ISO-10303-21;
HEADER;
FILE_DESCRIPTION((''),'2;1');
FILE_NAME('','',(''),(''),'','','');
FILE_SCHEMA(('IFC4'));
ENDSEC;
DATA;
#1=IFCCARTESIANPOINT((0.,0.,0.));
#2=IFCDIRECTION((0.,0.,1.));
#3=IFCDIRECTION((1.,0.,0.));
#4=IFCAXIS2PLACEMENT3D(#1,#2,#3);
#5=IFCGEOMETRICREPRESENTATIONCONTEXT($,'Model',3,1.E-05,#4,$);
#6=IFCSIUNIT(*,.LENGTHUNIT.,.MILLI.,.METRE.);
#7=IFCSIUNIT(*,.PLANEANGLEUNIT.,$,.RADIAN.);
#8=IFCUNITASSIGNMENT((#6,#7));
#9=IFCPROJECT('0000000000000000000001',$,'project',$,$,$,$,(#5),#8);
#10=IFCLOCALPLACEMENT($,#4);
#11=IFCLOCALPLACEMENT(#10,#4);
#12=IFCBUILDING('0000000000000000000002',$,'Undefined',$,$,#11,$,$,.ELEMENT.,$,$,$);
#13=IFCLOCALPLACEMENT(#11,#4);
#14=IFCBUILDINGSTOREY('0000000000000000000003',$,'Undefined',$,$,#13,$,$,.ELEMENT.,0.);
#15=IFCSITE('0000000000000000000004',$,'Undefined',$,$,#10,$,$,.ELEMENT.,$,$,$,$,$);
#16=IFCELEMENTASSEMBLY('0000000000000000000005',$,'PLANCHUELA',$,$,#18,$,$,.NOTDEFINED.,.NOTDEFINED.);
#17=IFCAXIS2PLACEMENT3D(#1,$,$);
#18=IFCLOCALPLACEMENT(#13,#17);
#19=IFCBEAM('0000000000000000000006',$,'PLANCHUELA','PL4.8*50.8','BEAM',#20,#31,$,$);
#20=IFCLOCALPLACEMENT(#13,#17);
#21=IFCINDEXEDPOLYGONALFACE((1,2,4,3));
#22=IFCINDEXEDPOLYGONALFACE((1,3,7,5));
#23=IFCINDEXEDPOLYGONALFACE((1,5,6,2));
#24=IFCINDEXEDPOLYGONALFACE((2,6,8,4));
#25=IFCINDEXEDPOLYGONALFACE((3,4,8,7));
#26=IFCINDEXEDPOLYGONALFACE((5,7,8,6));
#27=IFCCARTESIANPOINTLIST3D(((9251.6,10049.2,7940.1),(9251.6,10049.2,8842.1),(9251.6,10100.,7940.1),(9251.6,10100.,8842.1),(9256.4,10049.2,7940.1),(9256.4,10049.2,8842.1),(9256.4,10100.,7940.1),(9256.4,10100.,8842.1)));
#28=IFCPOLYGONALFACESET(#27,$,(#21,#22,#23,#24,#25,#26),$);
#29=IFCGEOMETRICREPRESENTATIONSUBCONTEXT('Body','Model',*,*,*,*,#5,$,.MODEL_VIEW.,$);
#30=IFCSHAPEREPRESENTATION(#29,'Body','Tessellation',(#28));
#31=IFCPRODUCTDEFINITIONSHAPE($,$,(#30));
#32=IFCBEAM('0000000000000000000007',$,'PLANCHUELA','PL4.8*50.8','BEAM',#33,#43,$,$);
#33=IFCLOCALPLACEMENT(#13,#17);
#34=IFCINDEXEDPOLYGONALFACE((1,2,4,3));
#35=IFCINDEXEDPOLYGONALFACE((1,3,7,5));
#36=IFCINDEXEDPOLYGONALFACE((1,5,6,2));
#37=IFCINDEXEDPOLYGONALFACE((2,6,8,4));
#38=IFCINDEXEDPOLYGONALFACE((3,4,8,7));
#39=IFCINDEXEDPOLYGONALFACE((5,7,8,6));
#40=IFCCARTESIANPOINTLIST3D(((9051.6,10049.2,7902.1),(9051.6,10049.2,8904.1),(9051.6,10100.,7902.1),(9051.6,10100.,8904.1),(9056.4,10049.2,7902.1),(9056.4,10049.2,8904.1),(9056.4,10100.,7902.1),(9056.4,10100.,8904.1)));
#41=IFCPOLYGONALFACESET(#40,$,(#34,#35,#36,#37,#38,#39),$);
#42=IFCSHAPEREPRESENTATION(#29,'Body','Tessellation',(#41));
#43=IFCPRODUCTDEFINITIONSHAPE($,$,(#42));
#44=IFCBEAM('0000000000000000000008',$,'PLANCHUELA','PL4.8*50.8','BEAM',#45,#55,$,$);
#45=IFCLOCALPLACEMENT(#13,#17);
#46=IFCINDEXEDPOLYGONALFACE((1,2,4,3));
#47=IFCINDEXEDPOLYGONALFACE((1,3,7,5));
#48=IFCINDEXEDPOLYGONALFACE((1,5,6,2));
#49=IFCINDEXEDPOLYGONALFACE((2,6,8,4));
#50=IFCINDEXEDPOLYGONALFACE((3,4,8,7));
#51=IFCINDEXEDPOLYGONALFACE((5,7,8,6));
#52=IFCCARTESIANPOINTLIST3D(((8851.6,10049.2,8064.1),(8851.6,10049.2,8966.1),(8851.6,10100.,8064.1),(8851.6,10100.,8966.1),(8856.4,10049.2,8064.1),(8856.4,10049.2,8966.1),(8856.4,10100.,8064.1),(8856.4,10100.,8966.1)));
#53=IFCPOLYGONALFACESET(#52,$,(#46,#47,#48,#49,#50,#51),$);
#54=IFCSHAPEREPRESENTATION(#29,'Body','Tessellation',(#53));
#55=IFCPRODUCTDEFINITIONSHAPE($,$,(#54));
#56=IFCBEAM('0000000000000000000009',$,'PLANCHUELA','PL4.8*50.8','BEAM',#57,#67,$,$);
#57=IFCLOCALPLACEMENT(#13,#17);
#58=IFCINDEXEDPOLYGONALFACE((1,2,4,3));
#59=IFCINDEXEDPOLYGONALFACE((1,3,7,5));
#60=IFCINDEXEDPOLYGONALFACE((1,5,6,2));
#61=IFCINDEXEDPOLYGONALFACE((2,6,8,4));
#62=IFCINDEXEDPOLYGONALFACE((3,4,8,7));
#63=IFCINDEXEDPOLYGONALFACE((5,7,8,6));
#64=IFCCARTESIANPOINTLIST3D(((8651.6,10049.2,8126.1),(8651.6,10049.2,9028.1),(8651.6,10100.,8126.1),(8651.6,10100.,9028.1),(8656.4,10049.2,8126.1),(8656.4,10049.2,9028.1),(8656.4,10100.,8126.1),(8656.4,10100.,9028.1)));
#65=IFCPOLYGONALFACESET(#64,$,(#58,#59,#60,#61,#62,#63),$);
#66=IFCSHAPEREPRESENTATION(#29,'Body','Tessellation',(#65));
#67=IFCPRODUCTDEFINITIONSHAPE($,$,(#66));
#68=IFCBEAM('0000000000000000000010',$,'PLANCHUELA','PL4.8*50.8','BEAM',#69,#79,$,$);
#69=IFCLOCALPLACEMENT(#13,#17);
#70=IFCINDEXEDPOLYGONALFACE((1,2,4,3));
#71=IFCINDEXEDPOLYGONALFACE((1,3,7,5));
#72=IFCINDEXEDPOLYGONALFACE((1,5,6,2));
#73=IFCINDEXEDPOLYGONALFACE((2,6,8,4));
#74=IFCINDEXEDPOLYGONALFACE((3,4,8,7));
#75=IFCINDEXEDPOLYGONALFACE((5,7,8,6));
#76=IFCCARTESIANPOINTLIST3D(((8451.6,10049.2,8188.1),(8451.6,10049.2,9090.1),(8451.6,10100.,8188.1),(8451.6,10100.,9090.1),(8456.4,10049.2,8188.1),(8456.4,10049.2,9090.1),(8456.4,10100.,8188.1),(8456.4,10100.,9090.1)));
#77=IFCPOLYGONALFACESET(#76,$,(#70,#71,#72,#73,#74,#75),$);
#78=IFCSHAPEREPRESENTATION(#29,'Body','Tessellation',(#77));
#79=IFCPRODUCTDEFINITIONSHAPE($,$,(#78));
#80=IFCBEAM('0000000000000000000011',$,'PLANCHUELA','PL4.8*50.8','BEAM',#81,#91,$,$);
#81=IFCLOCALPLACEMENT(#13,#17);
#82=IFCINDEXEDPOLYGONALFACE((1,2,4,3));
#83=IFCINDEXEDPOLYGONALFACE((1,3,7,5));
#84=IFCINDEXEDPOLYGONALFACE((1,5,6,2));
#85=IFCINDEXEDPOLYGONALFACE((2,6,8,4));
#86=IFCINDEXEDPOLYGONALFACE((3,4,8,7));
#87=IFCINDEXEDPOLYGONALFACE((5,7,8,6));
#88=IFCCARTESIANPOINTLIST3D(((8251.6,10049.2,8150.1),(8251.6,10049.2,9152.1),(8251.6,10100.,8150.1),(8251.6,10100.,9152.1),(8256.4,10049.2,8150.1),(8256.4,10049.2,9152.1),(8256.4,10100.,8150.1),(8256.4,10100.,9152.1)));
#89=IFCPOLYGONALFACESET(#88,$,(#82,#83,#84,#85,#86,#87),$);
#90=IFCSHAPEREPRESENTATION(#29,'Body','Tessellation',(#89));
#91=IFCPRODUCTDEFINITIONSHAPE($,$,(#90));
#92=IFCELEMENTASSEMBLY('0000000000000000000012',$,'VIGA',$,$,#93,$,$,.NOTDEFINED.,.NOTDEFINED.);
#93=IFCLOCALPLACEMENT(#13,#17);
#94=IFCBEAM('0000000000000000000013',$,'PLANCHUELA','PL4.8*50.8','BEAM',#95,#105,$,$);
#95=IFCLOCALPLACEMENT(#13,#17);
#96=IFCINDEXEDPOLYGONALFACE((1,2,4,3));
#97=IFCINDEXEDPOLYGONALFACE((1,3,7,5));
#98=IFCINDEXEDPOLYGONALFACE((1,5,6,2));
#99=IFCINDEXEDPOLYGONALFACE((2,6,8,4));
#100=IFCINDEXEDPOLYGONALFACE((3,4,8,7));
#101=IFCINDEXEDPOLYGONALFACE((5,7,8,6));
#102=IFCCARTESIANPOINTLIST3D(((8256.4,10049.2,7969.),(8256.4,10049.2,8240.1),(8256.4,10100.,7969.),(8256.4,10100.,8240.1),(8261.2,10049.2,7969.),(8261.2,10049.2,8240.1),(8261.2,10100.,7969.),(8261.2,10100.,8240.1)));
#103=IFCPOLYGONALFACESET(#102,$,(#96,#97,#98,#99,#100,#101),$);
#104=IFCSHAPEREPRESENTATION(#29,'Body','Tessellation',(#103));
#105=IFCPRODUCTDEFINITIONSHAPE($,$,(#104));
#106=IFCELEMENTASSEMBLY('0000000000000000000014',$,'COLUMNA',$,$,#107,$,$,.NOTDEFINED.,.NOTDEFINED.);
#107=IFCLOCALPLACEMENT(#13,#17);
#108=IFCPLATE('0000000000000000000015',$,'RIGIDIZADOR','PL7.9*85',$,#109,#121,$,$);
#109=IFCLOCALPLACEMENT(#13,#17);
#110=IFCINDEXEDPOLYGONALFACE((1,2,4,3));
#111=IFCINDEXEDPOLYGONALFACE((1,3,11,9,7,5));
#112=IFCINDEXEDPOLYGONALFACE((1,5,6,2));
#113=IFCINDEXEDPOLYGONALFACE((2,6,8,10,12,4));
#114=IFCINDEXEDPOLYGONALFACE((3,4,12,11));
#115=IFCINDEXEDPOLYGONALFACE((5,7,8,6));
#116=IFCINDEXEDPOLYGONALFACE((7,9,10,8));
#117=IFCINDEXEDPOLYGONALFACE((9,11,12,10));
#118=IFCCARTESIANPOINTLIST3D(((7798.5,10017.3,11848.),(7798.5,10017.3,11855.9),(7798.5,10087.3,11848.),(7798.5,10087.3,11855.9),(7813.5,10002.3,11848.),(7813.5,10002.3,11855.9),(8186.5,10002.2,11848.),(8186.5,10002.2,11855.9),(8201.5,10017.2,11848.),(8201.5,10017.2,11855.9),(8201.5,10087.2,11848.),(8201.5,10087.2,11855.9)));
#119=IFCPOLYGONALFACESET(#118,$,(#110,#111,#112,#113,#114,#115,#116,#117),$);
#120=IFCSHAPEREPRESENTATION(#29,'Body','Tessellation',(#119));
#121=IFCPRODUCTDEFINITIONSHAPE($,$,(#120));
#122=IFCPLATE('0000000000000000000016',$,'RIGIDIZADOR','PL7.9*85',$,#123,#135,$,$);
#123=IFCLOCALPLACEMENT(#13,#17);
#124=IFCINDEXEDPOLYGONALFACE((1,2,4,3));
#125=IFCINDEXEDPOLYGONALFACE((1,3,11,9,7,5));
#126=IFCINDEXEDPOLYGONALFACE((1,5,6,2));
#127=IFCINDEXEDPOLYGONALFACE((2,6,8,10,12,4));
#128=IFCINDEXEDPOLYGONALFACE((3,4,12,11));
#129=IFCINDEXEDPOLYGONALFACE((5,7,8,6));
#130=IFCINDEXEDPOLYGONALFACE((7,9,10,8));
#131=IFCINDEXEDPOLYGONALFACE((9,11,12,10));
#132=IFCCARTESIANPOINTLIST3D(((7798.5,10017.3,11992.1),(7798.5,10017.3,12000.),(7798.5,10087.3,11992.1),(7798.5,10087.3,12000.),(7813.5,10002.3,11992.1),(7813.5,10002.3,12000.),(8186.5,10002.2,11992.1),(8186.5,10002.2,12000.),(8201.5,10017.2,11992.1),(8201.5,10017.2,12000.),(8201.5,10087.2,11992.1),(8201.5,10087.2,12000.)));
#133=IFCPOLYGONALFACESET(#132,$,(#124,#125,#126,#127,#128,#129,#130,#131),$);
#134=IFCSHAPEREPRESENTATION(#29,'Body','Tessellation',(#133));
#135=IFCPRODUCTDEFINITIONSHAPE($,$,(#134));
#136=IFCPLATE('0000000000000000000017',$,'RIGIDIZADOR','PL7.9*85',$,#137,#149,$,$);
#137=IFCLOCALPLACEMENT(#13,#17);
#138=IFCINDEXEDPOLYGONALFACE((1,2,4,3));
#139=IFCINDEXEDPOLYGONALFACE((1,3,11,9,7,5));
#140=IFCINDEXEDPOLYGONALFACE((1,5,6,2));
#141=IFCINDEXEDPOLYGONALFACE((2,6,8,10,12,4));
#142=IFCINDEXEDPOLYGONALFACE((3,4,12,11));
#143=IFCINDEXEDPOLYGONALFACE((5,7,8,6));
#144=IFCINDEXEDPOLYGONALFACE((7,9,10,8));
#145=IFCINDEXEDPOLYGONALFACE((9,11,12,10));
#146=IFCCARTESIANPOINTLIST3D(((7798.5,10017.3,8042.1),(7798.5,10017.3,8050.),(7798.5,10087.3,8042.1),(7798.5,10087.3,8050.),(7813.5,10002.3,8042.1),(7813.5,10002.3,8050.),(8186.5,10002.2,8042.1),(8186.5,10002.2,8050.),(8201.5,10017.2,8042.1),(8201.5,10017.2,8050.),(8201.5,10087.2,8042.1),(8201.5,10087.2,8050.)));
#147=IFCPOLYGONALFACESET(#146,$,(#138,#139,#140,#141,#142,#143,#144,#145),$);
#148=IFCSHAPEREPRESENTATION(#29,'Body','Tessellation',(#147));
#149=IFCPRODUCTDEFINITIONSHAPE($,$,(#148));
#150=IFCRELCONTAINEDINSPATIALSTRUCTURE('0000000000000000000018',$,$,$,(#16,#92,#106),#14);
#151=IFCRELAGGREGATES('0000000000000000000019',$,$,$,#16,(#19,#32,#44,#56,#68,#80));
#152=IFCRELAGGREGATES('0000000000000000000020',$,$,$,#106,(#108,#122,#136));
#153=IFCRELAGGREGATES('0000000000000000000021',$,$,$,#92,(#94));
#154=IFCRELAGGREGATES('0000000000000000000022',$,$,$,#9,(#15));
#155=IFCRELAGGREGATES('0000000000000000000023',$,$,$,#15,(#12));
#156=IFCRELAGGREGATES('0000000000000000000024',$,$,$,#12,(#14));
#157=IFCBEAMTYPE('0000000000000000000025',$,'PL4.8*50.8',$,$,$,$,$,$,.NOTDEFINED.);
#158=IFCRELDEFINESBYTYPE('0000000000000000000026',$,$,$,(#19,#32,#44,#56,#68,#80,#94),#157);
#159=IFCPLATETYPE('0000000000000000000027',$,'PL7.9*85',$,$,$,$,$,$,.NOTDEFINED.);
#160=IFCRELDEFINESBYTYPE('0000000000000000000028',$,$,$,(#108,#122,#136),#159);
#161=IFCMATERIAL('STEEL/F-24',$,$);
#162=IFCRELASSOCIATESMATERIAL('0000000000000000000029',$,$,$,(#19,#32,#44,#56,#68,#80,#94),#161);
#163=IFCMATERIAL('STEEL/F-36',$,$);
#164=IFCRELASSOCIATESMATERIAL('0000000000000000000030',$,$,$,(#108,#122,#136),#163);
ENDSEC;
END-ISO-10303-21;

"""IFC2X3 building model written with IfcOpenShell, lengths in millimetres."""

from ifc_helpers import new_model, si_unit, frame, origin_with_axes, origin_2d_with_axis, place, context, subcontext, project, spatial, polyline, rectangle, outline, extrude, material, type_object, element, aggregate, save


model = new_model("IFC2X3")

# Units and contexts
model_context = context("Model", 3, precision=1e-05, world=origin_with_axes())
body_context = subcontext(model_context, "Body", "Model", "MODEL_VIEW")
ifc_project = project(units=[si_unit("LENGTHUNIT", "METRE", prefix="MILLI"), si_unit("PLANEANGLEUNIT", "RADIAN")], contexts=[model_context])

# Site, building, storey
site_placement = place(None, origin_with_axes())
site = spatial("IfcSite", under=ifc_project, at=site_placement, Name="Undefined", CompositionType="ELEMENT")
building_placement = place(site_placement, origin_with_axes())
building = spatial("IfcBuilding", under=site, at=building_placement, Name="Undefined", CompositionType="ELEMENT")
storey_placement = place(building_placement, origin_with_axes())
storey = spatial("IfcBuildingStorey", under=building, at=storey_placement, Name="Undefined", CompositionType="ELEMENT", Elevation=0.0)

# Element assembly, beams
assembly_1_placement = place(storey_placement, origin_with_axes())
assembly_1 = element("IfcElementAssembly", 1, at=assembly_1_placement, inside=storey, Name="PLANCHUELA", AssemblyPlace="NOTDEFINED", PredefinedType="NOTDEFINED")
ifc_material_1 = material(Name="STEEL/F-24")
beam_type = type_object("IfcBeamType", Name="PL4.8*50.8", PredefinedType="NOTDEFINED")
beam_1_placement = place(assembly_1_placement, frame((9254.0, 10074.6, 8842.1), z_axis=(0.0, -1.0, 0.0), x_axis=(0.0, 0.0, -1.0)))
beam_1 = element("IfcBeam", 2, at=beam_1_placement, type_object=beam_type, material=ifc_material_1, Name="PLANCHUELA", Description="PL4.8*50.8", ObjectType="BEAM", context=body_context, shape_type="SweptSolid", body=[
    extrude(rectangle(XDim=4.8, YDim=50.8, at=origin_2d_with_axis()), frame((902.0, 0.0, 0.0), z_axis=(-1.0, 0.0, 0.0), x_axis=(0.0, -1.0, 0.0)), (0.0, 0.0, 1.0), 902.0),
])
beam_2_placement = place(assembly_1_placement, frame((9054.0, 10074.6, 8904.1), z_axis=(0.0, -1.0, 0.0), x_axis=(0.0, 0.0, -1.0)))
beam_2 = element("IfcBeam", 3, at=beam_2_placement, type_object=beam_type, material=ifc_material_1, Name="PLANCHUELA", Description="PL4.8*50.8", ObjectType="BEAM", context=body_context, shape_type="SweptSolid", body=[
    extrude(rectangle(XDim=4.8, YDim=50.8, at=origin_2d_with_axis()), frame((1002.0, 0.0, 0.0), z_axis=(-1.0, 0.0, 0.0), x_axis=(0.0, -1.0, 0.0)), (0.0, 0.0, 1.0), 1002.0),
])
beam_3_placement = place(assembly_1_placement, frame((8854.0, 10074.6, 8966.1), z_axis=(0.0, -1.0, 0.0), x_axis=(0.0, 0.0, -1.0)))
beam_3 = element("IfcBeam", 4, at=beam_3_placement, type_object=beam_type, material=ifc_material_1, Name="PLANCHUELA", Description="PL4.8*50.8", ObjectType="BEAM", context=body_context, shape_type="SweptSolid", body=[
    extrude(rectangle(XDim=4.8, YDim=50.8, at=origin_2d_with_axis()), frame((902.0, 0.0, 0.0), z_axis=(-1.0, 0.0, 0.0), x_axis=(0.0, -1.0, 0.0)), (0.0, 0.0, 1.0), 902.0),
])
beam_4_placement = place(assembly_1_placement, frame((8654.0, 10074.6, 9028.1), z_axis=(0.0, -1.0, 0.0), x_axis=(0.0, 0.0, -1.0)))
beam_4 = element("IfcBeam", 5, at=beam_4_placement, type_object=beam_type, material=ifc_material_1, Name="PLANCHUELA", Description="PL4.8*50.8", ObjectType="BEAM", context=body_context, shape_type="SweptSolid", body=[
    extrude(rectangle(XDim=4.8, YDim=50.8, at=origin_2d_with_axis()), frame((902.0, 0.0, 0.0), z_axis=(-1.0, 0.0, 0.0), x_axis=(0.0, -1.0, 0.0)), (0.0, 0.0, 1.0), 902.0),
])
beam_5_placement = place(assembly_1_placement, frame((8454.0, 10074.6, 9090.1), z_axis=(0.0, -1.0, 0.0), x_axis=(0.0, 0.0, -1.0)))
beam_5 = element("IfcBeam", 6, at=beam_5_placement, type_object=beam_type, material=ifc_material_1, Name="PLANCHUELA", Description="PL4.8*50.8", ObjectType="BEAM", context=body_context, shape_type="SweptSolid", body=[
    extrude(rectangle(XDim=4.8, YDim=50.8, at=origin_2d_with_axis()), frame((902.0, 0.0, 0.0), z_axis=(-1.0, 0.0, 0.0), x_axis=(0.0, -1.0, 0.0)), (0.0, 0.0, 1.0), 902.0),
])
beam_6_placement = place(assembly_1_placement, frame((8254.0, 10074.6, 9152.1), z_axis=(0.0, -1.0, 0.0), x_axis=(0.0, 0.0, -1.0)))
beam_6 = element("IfcBeam", 7, at=beam_6_placement, type_object=beam_type, material=ifc_material_1, Name="PLANCHUELA", Description="PL4.8*50.8", ObjectType="BEAM", context=body_context, shape_type="SweptSolid", body=[
    extrude(rectangle(XDim=4.8, YDim=50.8, at=origin_2d_with_axis()), frame((1002.0, 0.0, 0.0), z_axis=(-1.0, 0.0, 0.0), x_axis=(0.0, -1.0, 0.0)), (0.0, 0.0, 1.0), 1002.0),
])
aggregate(assembly_1, [beam_1, beam_2, beam_3, beam_4, beam_5, beam_6])

# Element assembly, beam
assembly_2_placement = place(storey_placement, origin_with_axes())
assembly_2 = element("IfcElementAssembly", 8, at=assembly_2_placement, inside=storey, Name="VIGA", AssemblyPlace="NOTDEFINED", PredefinedType="NOTDEFINED")
beam_7_placement = place(assembly_2_placement, frame((8258.8, 10074.6, 8240.1), z_axis=(0.0, 1.0, 0.0), x_axis=(0.0, 0.0, -1.0)))
beam_7 = element("IfcBeam", 9, at=beam_7_placement, type_object=beam_type, material=ifc_material_1, Name="PLANCHUELA", Description="PL4.8*50.8", ObjectType="BEAM", context=body_context, shape_type="SweptSolid", body=[
    extrude(rectangle(XDim=4.8, YDim=50.8, at=origin_2d_with_axis()), frame((271.0, 0.0, 0.0), z_axis=(-1.0, 0.0, 0.0), x_axis=(0.0, -1.0, 0.0)), (0.0, 0.0, 1.0), 271.0),
])

# Element assembly, plates
assembly_3_placement = place(storey_placement, origin_with_axes())
assembly_3 = element("IfcElementAssembly", 10, at=assembly_3_placement, inside=storey, Name="COLUMNA", AssemblyPlace="NOTDEFINED", PredefinedType="NOTDEFINED")
ifc_material_2 = material(Name="STEEL/F-36")
plate_type = type_object("IfcPlateType", Name="PL7.9*85", PredefinedType="NOTDEFINED")
plate_1_placement = place(assembly_3_placement, frame((8201.5, 10002.2, 11851.9), z_axis=(0.0, 0.0, 1.0), x_axis=(0.0, 1.0, 0.0)))
plate_1 = element("IfcPlate", 11, at=plate_1_placement, type_object=plate_type, material=ifc_material_2, Name="RIGIDIZADOR", Description="PL7.9*85", context=body_context, shape_type="SweptSolid", body=[
    extrude(outline(polyline([(0.0, 15.0), (15.0, 0.0), (85.0, 0.0), (85.0, 403.0), (15.0, 403.0), (0.0, 388.0), (0.0, 15.0)])), frame((0.0, 0.0, -4.0), z_axis=(0.0, 0.0, 1.0), x_axis=(1.0, 0.0, 0.0)), (0.0, 0.0, 1.0), 7.9),
])
plate_2_placement = place(assembly_3_placement, frame((8201.5, 10002.2, 11996.0), z_axis=(0.0, 0.0, 1.0), x_axis=(0.0, 1.0, 0.0)))
plate_2 = element("IfcPlate", 12, at=plate_2_placement, type_object=plate_type, material=ifc_material_2, Name="RIGIDIZADOR", Description="PL7.9*85", context=body_context, shape_type="SweptSolid", body=[
    extrude(outline(polyline([(0.0, 15.0), (15.0, 0.0), (85.0, 0.0), (85.0, 403.0), (15.0, 403.0), (0.0, 388.0), (0.0, 15.0)])), frame((0.0, 0.0, -4.0), z_axis=(0.0, 0.0, 1.0), x_axis=(1.0, 0.0, 0.0)), (0.0, 0.0, 1.0), 7.9),
])
plate_3_placement = place(assembly_3_placement, frame((8201.5, 10002.2, 8046.1), z_axis=(0.0, 0.0, 1.0), x_axis=(0.0, 1.0, 0.0)))
plate_3 = element("IfcPlate", 13, at=plate_3_placement, type_object=plate_type, material=ifc_material_2, Name="RIGIDIZADOR", Description="PL7.9*85", context=body_context, shape_type="SweptSolid", body=[
    extrude(outline(polyline([(0.0, 15.0), (15.0, 0.0), (85.0, 0.0), (85.0, 403.0), (15.0, 403.0), (0.0, 388.0), (0.0, 15.0)])), frame((0.0, 0.0, -4.0), z_axis=(0.0, 0.0, 1.0), x_axis=(1.0, 0.0, 0.0)), (0.0, 0.0, 1.0), 7.9),
])
aggregate(assembly_3, [plate_1, plate_2, plate_3])

aggregate(assembly_2, [beam_7])

save(model, "model.ifc")
